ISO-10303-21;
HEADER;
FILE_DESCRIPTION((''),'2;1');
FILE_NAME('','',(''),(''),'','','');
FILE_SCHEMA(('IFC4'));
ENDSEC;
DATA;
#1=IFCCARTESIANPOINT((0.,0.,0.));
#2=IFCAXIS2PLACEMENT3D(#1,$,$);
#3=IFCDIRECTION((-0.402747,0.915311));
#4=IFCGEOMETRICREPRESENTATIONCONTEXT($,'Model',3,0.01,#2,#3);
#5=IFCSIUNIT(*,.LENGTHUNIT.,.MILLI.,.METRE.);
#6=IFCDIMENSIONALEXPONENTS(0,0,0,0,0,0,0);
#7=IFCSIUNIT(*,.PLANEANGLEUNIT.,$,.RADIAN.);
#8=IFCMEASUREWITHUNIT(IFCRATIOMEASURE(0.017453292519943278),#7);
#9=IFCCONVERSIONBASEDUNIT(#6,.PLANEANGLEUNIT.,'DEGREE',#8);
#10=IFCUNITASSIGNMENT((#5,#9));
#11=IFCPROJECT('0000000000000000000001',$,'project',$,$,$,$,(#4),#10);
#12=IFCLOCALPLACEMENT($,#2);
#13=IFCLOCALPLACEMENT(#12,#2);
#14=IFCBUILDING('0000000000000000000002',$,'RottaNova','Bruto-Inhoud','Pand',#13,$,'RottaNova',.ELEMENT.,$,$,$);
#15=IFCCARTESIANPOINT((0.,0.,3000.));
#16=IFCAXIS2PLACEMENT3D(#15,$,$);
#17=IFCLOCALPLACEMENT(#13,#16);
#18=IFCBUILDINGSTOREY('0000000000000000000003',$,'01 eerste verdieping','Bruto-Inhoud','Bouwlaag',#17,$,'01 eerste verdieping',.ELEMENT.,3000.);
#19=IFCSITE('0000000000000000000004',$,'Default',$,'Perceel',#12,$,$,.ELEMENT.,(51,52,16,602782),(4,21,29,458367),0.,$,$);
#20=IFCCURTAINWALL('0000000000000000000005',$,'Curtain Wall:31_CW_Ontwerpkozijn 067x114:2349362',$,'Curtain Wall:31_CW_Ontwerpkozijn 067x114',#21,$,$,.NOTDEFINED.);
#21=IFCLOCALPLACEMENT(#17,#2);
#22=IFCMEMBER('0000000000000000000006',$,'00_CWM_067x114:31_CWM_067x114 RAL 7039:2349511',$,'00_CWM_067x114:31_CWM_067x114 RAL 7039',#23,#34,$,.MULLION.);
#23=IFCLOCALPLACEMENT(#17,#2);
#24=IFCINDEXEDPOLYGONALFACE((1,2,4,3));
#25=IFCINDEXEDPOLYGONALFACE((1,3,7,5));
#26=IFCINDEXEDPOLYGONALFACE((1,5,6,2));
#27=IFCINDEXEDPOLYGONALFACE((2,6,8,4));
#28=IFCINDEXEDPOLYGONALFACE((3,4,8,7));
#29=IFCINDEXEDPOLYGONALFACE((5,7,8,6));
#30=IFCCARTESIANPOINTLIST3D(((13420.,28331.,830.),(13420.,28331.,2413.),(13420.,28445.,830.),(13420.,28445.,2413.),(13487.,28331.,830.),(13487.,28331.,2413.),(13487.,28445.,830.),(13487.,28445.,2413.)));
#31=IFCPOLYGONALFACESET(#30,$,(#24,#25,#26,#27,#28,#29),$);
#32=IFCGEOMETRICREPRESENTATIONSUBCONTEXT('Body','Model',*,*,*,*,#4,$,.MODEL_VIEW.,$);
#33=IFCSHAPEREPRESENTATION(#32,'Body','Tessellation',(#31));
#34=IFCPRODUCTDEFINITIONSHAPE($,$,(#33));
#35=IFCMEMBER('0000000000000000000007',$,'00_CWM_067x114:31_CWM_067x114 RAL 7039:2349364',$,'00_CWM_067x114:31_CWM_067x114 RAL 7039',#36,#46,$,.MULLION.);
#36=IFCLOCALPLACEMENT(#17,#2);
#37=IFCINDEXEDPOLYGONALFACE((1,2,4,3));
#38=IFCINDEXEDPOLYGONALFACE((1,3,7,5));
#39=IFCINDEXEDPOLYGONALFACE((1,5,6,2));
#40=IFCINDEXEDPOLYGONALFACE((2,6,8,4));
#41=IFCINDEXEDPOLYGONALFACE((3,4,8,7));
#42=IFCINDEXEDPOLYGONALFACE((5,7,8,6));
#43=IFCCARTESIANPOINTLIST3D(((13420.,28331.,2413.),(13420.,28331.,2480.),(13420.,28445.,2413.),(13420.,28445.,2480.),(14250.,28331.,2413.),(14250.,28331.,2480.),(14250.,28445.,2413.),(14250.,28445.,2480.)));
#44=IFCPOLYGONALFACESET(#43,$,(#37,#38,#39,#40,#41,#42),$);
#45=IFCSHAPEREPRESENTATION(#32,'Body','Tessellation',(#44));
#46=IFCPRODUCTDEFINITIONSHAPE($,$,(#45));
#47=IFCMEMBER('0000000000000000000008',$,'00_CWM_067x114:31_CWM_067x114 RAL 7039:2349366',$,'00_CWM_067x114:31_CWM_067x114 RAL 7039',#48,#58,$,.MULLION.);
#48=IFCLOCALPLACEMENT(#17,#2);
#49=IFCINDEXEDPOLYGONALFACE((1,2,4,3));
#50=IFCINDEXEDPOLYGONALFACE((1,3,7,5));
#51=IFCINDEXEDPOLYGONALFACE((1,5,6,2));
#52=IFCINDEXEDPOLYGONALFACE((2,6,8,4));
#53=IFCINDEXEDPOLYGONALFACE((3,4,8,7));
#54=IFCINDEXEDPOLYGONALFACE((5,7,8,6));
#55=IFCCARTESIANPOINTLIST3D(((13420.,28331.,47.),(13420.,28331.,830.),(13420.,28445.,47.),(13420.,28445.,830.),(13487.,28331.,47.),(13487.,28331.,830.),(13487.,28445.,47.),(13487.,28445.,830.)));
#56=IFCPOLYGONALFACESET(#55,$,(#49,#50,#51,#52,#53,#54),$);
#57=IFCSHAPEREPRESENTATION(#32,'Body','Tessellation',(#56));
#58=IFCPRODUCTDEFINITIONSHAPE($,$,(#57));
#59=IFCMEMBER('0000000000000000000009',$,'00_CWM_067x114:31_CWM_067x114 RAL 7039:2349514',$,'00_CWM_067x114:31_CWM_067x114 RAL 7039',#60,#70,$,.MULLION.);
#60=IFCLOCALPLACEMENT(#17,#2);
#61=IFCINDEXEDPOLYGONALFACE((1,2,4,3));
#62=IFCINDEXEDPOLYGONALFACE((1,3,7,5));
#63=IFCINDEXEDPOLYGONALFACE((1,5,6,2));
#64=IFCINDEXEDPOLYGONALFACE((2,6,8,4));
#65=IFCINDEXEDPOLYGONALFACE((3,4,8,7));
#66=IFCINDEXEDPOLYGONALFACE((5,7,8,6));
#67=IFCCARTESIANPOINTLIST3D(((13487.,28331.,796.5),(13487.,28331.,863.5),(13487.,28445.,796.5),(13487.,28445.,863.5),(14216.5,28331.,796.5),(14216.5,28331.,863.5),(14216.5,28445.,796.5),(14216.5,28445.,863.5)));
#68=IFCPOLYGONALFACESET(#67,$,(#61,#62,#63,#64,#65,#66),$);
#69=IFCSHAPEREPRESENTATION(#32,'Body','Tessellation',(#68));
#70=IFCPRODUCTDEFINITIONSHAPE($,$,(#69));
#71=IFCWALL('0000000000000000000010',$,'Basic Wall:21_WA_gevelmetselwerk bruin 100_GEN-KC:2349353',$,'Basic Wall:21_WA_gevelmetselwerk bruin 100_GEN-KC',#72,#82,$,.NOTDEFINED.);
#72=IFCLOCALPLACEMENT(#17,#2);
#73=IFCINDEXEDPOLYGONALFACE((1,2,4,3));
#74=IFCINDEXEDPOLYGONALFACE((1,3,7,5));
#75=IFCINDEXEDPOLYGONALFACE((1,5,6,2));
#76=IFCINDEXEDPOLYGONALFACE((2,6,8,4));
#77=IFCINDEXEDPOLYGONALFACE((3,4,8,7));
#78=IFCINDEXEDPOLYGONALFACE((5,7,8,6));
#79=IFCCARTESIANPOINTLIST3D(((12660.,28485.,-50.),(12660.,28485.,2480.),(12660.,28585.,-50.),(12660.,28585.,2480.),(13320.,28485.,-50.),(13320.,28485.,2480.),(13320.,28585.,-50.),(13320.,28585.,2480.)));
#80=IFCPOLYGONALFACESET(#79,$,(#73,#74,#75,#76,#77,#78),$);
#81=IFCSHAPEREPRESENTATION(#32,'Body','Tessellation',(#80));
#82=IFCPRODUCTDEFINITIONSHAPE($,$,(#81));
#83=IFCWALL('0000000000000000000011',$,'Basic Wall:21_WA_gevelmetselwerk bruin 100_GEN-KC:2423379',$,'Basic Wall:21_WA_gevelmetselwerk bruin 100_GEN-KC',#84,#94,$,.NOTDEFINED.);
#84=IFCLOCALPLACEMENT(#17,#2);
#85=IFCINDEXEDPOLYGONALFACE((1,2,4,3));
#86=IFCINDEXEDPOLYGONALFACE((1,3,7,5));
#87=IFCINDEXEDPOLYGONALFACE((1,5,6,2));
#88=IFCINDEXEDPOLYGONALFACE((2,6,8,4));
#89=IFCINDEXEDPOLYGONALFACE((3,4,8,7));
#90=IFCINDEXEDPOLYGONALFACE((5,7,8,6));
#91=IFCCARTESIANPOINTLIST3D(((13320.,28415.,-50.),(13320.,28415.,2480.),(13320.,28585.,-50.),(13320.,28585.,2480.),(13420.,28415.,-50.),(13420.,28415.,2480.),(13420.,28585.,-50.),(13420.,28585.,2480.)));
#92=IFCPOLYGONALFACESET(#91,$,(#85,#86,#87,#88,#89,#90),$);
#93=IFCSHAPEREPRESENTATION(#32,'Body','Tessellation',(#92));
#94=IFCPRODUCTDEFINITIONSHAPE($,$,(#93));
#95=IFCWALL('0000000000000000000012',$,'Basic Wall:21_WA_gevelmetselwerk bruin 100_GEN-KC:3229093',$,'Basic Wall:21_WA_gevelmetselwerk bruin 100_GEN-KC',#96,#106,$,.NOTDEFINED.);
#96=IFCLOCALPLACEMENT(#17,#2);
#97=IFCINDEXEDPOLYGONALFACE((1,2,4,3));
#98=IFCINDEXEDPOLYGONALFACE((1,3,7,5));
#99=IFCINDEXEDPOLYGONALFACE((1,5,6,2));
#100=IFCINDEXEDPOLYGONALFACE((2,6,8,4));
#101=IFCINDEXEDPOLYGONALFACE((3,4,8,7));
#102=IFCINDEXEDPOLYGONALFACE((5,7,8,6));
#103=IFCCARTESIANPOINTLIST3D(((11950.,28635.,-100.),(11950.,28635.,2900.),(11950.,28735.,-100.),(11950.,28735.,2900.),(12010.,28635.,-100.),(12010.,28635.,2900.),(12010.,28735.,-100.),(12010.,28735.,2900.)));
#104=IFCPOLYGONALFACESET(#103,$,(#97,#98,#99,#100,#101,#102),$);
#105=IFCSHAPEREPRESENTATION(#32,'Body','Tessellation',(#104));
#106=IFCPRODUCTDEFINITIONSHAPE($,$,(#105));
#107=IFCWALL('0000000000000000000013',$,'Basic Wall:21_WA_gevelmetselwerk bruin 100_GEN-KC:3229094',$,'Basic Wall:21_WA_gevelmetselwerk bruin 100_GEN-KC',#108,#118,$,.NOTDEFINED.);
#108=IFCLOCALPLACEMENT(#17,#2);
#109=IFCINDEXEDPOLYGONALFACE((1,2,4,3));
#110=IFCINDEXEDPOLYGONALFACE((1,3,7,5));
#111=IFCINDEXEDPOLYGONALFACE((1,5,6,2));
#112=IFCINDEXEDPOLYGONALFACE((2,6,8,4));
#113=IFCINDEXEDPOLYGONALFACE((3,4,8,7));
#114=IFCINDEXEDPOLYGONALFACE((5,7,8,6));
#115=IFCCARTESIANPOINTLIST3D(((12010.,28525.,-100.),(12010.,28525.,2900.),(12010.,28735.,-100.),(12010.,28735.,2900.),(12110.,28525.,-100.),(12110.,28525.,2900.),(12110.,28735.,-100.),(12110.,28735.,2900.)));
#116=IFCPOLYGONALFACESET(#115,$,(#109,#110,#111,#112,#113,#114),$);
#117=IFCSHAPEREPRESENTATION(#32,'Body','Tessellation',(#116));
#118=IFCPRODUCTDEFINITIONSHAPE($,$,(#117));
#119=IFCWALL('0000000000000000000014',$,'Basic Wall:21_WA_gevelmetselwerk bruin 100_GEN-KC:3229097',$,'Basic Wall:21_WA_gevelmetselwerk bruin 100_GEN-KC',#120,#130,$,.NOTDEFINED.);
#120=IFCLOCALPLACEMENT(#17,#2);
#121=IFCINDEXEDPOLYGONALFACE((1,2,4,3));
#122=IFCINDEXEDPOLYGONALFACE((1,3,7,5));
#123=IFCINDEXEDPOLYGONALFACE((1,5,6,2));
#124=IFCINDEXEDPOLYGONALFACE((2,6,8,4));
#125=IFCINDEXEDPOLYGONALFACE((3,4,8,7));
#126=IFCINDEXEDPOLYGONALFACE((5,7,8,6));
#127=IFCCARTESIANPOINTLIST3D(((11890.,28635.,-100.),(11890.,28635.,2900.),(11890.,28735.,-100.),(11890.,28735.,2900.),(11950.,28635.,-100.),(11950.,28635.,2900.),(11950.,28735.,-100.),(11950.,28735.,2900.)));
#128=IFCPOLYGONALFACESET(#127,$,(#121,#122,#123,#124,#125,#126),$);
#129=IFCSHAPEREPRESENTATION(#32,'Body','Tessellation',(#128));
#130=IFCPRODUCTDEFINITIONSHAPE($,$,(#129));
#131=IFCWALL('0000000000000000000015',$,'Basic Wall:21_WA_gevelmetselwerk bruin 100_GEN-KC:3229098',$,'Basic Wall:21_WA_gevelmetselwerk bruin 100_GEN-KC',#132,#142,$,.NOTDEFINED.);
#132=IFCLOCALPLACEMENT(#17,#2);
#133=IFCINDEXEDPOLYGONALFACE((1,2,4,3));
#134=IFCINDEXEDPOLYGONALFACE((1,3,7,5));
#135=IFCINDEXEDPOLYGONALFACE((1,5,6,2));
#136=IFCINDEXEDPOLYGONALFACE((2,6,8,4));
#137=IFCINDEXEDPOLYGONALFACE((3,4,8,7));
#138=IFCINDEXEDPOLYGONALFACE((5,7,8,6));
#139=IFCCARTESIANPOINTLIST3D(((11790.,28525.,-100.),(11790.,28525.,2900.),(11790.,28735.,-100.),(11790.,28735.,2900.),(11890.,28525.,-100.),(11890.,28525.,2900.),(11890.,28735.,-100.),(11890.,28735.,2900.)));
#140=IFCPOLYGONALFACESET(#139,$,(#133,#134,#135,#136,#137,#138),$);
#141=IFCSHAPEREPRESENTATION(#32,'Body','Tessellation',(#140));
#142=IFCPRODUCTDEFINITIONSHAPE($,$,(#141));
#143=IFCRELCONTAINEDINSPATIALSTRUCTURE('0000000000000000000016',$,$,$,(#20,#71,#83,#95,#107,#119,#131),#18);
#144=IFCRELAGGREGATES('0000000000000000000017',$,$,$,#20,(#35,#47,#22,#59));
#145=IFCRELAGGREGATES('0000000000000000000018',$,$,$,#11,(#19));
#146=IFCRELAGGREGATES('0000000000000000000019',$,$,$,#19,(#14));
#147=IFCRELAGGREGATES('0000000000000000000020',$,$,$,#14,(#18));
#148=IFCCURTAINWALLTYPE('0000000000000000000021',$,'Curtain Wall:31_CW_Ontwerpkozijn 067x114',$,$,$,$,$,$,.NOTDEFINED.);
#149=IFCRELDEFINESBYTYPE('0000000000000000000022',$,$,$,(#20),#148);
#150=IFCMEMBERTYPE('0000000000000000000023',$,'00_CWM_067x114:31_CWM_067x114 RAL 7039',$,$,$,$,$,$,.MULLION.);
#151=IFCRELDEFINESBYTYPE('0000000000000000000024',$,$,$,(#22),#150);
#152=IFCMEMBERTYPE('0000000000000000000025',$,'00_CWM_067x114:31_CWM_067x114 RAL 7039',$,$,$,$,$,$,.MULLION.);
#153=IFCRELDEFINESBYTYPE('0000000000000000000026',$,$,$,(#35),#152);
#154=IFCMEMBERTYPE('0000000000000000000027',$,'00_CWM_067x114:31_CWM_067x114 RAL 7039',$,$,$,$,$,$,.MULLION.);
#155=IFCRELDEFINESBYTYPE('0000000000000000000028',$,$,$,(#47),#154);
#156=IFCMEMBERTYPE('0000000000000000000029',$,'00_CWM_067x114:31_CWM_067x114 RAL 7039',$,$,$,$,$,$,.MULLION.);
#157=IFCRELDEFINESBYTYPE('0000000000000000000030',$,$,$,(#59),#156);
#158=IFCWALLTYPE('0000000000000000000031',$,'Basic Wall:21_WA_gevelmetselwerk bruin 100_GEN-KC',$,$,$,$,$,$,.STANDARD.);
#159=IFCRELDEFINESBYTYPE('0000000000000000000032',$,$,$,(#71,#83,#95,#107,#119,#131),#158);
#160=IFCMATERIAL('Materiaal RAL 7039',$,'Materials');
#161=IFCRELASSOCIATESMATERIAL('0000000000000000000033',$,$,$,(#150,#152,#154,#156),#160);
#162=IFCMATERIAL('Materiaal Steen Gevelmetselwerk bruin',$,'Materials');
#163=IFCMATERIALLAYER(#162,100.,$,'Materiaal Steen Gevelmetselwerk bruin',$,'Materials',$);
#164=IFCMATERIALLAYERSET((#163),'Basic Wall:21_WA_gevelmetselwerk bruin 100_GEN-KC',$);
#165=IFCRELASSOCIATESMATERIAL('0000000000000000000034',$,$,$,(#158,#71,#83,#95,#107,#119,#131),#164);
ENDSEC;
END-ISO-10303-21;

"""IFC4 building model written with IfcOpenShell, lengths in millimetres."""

from ifc_helpers import new_model, entity, si_unit, converted_unit, direction, frame, frame_2d, origin, origin_2d_with_axis, place, context, subcontext, project, spatial, rectangle, extrude, source, transform, mapped, material, layer, layer_set, material_profile, profile_set, type_object, type_shapes, element, aggregate, save


model = new_model("IFC4")

# Units and contexts
model_context = context("Model", 3, precision=0.01, world=origin(), true_north=direction((-0.402747, 0.915311)))
body_context = subcontext(model_context, "Body", "Model", "MODEL_VIEW")
ifc_project = project(units=[si_unit("LENGTHUNIT", "METRE", prefix="MILLI"), converted_unit("PLANEANGLEUNIT", "DEGREE", entity("IfcRatioMeasure", 0.017453292519943278), si_unit("PLANEANGLEUNIT", "RADIAN"), dimensions=[0, 0, 0, 0, 0, 0, 0])], contexts=[model_context])

# Site, building, storey
site_placement = place(None, origin())
site = spatial("IfcSite", under=ifc_project, at=site_placement, Name="Default", ObjectType="Perceel", CompositionType="ELEMENT", RefLatitude=(51, 52, 16, 602782), RefLongitude=(4, 21, 29, 458367), RefElevation=0.0)
building_placement = place(site_placement, origin())
building = spatial("IfcBuilding", under=site, at=building_placement, Name="RottaNova", Description="Bruto-Inhoud", ObjectType="Pand", LongName="RottaNova", CompositionType="ELEMENT")
storey_placement = place(building_placement, frame((0.0, 0.0, 3000.0)))
storey = spatial("IfcBuildingStorey", under=building, at=storey_placement, Name="01 eerste verdieping", Description="Bruto-Inhoud", ObjectType="Bouwlaag", LongName="01 eerste verdieping", CompositionType="ELEMENT", Elevation=3000.0)

# Curtain wall, members
curtain_wall_type = type_object("IfcCurtainWallType", Name="Curtain Wall:31_CW_Ontwerpkozijn 067x114", PredefinedType="NOTDEFINED")
curtain_wall_placement = place(storey_placement, frame((0.0, 0.0, -3000.0)))
curtain_wall = element("IfcCurtainWall", 1, at=curtain_wall_placement, inside=storey, type_object=curtain_wall_type, Name="Curtain Wall:31_CW_Ontwerpkozijn 067x114:2349362", ObjectType="Curtain Wall:31_CW_Ontwerpkozijn 067x114", PredefinedType="NOTDEFINED")
ifc_material_1 = material(Name="Materiaal RAL 7039", Category="Materials")
ifc_material_profile = material_profile(ifc_material_1, rectangle(XDim=114.0, YDim=67.0, at=origin_2d_with_axis()), Name="31_CWM_067x114 RAL 7039")
ifc_profile_set = profile_set([ifc_material_profile], Name="31_CWM_067x114 RAL 7039")
member_type_1 = type_object("IfcMemberType", Name="00_CWM_067x114:31_CWM_067x114 RAL 7039", PredefinedType="MULLION", material=ifc_profile_set)
shared_shape_1 = source(origin(), body_context, "Body", "SweptSolid", [
    extrude(rectangle(XDim=114.0, YDim=67.0, at=origin_2d_with_axis()), frame((-33.5, 57.0, -1583.0), z_axis=(0.0, 0.0, 1.0), x_axis=(0.0, -1.0, 0.0)), (0.0, 0.0, 1.0), 1583.0),
])
type_shapes(member_type_1, [shared_shape_1])
member_1_placement = place(curtain_wall_placement, frame((13420.0, 28331.0, 3830.0), z_axis=(0.0, 0.0, -1.0), x_axis=(-1.0, 0.0, 0.0)))
member_1 = element("IfcMember", 2, at=member_1_placement, type_object=member_type_1, Name="00_CWM_067x114:31_CWM_067x114 RAL 7039:2349511", ObjectType="00_CWM_067x114:31_CWM_067x114 RAL 7039", PredefinedType="MULLION", context=body_context, shape_type="MappedRepresentation", body=[
    mapped(shared_shape_1, transform((0.0, 0.0, 0.0), scale=1.0)),
])
member_type_2 = type_object("IfcMemberType", Name="00_CWM_067x114:31_CWM_067x114 RAL 7039", PredefinedType="MULLION", material=ifc_profile_set)
shared_shape_2 = source(origin(), body_context, "Body", "SweptSolid", [
    extrude(rectangle(XDim=114.0, YDim=67.0, at=origin_2d_with_axis()), frame((-33.5, 57.0, -830.0), z_axis=(0.0, 0.0, 1.0), x_axis=(0.0, -1.0, 0.0)), (0.0, 0.0, 1.0), 830.0),
])
type_shapes(member_type_2, [shared_shape_2])
member_2_placement = place(curtain_wall_placement, frame((13420.0, 28331.0, 5480.0), z_axis=(-1.0, 0.0, 0.0), x_axis=(0.0, 0.0, 1.0)))
member_2 = element("IfcMember", 3, at=member_2_placement, type_object=member_type_2, Name="00_CWM_067x114:31_CWM_067x114 RAL 7039:2349364", ObjectType="00_CWM_067x114:31_CWM_067x114 RAL 7039", PredefinedType="MULLION", context=body_context, shape_type="MappedRepresentation", body=[
    mapped(shared_shape_2, transform((0.0, 0.0, 0.0), scale=1.0)),
])
member_type_3 = type_object("IfcMemberType", Name="00_CWM_067x114:31_CWM_067x114 RAL 7039", PredefinedType="MULLION", material=ifc_profile_set)
shared_shape_3 = source(origin(), body_context, "Body", "SweptSolid", [
    extrude(rectangle(XDim=114.0, YDim=67.0, at=origin_2d_with_axis()), frame((-33.5, 57.0, -783.0), z_axis=(0.0, 0.0, 1.0), x_axis=(0.0, -1.0, 0.0)), (0.0, 0.0, 1.0), 783.0),
])
type_shapes(member_type_3, [shared_shape_3])
member_3_placement = place(curtain_wall_placement, frame((13420.0, 28331.0, 3047.0), z_axis=(0.0, 0.0, -1.0), x_axis=(-1.0, 0.0, 0.0)))
member_3 = element("IfcMember", 4, at=member_3_placement, type_object=member_type_3, Name="00_CWM_067x114:31_CWM_067x114 RAL 7039:2349366", ObjectType="00_CWM_067x114:31_CWM_067x114 RAL 7039", PredefinedType="MULLION", context=body_context, shape_type="MappedRepresentation", body=[
    mapped(shared_shape_3, transform((0.0, 0.0, 0.0), scale=1.0)),
])
member_type_4 = type_object("IfcMemberType", Name="00_CWM_067x114:31_CWM_067x114 RAL 7039", PredefinedType="MULLION", material=ifc_profile_set)
shared_shape_4 = source(origin(), body_context, "Body", "SweptSolid", [
    extrude(rectangle(XDim=114.0, YDim=67.0, at=origin_2d_with_axis()), frame((0.0, 57.0, -729.5), z_axis=(0.0, 0.0, 1.0), x_axis=(0.0, -1.0, 0.0)), (0.0, 0.0, 1.0), 729.5),
])
type_shapes(member_type_4, [shared_shape_4])
member_4_placement = place(curtain_wall_placement, frame((13487.0, 28331.0, 3830.0), z_axis=(-1.0, 0.0, 0.0), x_axis=(0.0, 0.0, 1.0)))
member_4 = element("IfcMember", 5, at=member_4_placement, type_object=member_type_4, Name="00_CWM_067x114:31_CWM_067x114 RAL 7039:2349514", ObjectType="00_CWM_067x114:31_CWM_067x114 RAL 7039", PredefinedType="MULLION", context=body_context, shape_type="MappedRepresentation", body=[
    mapped(shared_shape_4, transform((0.0, 0.0, 0.0), scale=1.0)),
])
aggregate(curtain_wall, [member_2, member_3, member_1, member_4])

# Walls
ifc_material_2 = material(Name="Materiaal Steen Gevelmetselwerk bruin", Category="Materials")
ifc_layer_1 = layer(ifc_material_2, 100.0, Name="Materiaal Steen Gevelmetselwerk bruin", Category="Materials")
ifc_layer_set_1 = layer_set([ifc_layer_1], Name="Basic Wall:21_WA_gevelmetselwerk bruin 100_GEN-KC")
wall_type_1 = type_object("IfcWallType", Name="Basic Wall:21_WA_gevelmetselwerk bruin 100_GEN-KC", PredefinedType="STANDARD", material=ifc_layer_set_1)
wall_1_placement = place(storey_placement, frame((12660.0, 28535.0, -50.0)))
element("IfcWall", 6, at=wall_1_placement, inside=storey, type_object=wall_type_1, material=ifc_layer_set_1, Name="Basic Wall:21_WA_gevelmetselwerk bruin 100_GEN-KC:2349353", ObjectType="Basic Wall:21_WA_gevelmetselwerk bruin 100_GEN-KC", PredefinedType="NOTDEFINED", context=body_context, shape_type="SweptSolid", body=[
    extrude(rectangle(XDim=660.0, YDim=100.0, at=frame_2d((330.0, 0.0), x_axis=(-1.0, 0.0))), origin(), (0.0, 0.0, 1.0), 2530.0),
])
wall_2_placement = place(storey_placement, frame((13370.0, 28415.0, -50.0), z_axis=(0.0, 0.0, 1.0), x_axis=(0.0, 1.0, 0.0)))
element("IfcWall", 7, at=wall_2_placement, inside=storey, type_object=wall_type_1, material=ifc_layer_set_1, Name="Basic Wall:21_WA_gevelmetselwerk bruin 100_GEN-KC:2423379", ObjectType="Basic Wall:21_WA_gevelmetselwerk bruin 100_GEN-KC", PredefinedType="NOTDEFINED", context=body_context, shape_type="SweptSolid", body=[
    extrude(rectangle(XDim=170.0, YDim=100.0, at=frame_2d((85.0, 0.0), x_axis=(-1.0, 0.0))), origin(), (0.0, 0.0, 1.0), 2530.0),
])
wall_3_placement = place(storey_placement, frame((12010.0, 28685.0, -100.0), z_axis=(0.0, 0.0, 1.0), x_axis=(-1.0, 0.0, 0.0)))
element("IfcWall", 8, at=wall_3_placement, inside=storey, type_object=wall_type_1, material=ifc_layer_set_1, Name="Basic Wall:21_WA_gevelmetselwerk bruin 100_GEN-KC:3229093", ObjectType="Basic Wall:21_WA_gevelmetselwerk bruin 100_GEN-KC", PredefinedType="NOTDEFINED", context=body_context, shape_type="SweptSolid", body=[
    extrude(rectangle(XDim=60.0, YDim=100.0, at=frame_2d((30.0, 0.0), x_axis=(-1.0, 0.0))), origin(), (0.0, 0.0, 1.0), 3000.0),
])
wall_4_placement = place(storey_placement, frame((12060.0, 28735.0, -100.0), z_axis=(0.0, 0.0, 1.0), x_axis=(0.0, -1.0, 0.0)))
element("IfcWall", 9, at=wall_4_placement, inside=storey, type_object=wall_type_1, material=ifc_layer_set_1, Name="Basic Wall:21_WA_gevelmetselwerk bruin 100_GEN-KC:3229094", ObjectType="Basic Wall:21_WA_gevelmetselwerk bruin 100_GEN-KC", PredefinedType="NOTDEFINED", context=body_context, shape_type="SweptSolid", body=[
    extrude(rectangle(XDim=210.0, YDim=100.0, at=frame_2d((105.0, 0.0), x_axis=(-1.0, 0.0))), origin(), (0.0, 0.0, 1.0), 3000.0),
])
wall_5_placement = place(storey_placement, frame((11890.0, 28685.0, -100.0)))
element("IfcWall", 10, at=wall_5_placement, inside=storey, type_object=wall_type_1, material=ifc_layer_set_1, Name="Basic Wall:21_WA_gevelmetselwerk bruin 100_GEN-KC:3229097", ObjectType="Basic Wall:21_WA_gevelmetselwerk bruin 100_GEN-KC", PredefinedType="NOTDEFINED", context=body_context, shape_type="SweptSolid", body=[
    extrude(rectangle(XDim=60.0, YDim=100.0, at=frame_2d((30.0, 0.0), x_axis=(-1.0, 0.0))), origin(), (0.0, 0.0, 1.0), 3000.0),
])
wall_6_placement = place(storey_placement, frame((11840.0, 28735.0, -100.0), z_axis=(0.0, 0.0, 1.0), x_axis=(0.0, -1.0, 0.0)))
element("IfcWall", 11, at=wall_6_placement, inside=storey, type_object=wall_type_1, material=ifc_layer_set_1, Name="Basic Wall:21_WA_gevelmetselwerk bruin 100_GEN-KC:3229098", ObjectType="Basic Wall:21_WA_gevelmetselwerk bruin 100_GEN-KC", PredefinedType="NOTDEFINED", context=body_context, shape_type="SweptSolid", body=[
    extrude(rectangle(XDim=210.0, YDim=100.0, at=frame_2d((105.0, 0.0), x_axis=(-1.0, 0.0))), origin(), (0.0, 0.0, 1.0), 3000.0),
])

save(model, "model.ifc")
